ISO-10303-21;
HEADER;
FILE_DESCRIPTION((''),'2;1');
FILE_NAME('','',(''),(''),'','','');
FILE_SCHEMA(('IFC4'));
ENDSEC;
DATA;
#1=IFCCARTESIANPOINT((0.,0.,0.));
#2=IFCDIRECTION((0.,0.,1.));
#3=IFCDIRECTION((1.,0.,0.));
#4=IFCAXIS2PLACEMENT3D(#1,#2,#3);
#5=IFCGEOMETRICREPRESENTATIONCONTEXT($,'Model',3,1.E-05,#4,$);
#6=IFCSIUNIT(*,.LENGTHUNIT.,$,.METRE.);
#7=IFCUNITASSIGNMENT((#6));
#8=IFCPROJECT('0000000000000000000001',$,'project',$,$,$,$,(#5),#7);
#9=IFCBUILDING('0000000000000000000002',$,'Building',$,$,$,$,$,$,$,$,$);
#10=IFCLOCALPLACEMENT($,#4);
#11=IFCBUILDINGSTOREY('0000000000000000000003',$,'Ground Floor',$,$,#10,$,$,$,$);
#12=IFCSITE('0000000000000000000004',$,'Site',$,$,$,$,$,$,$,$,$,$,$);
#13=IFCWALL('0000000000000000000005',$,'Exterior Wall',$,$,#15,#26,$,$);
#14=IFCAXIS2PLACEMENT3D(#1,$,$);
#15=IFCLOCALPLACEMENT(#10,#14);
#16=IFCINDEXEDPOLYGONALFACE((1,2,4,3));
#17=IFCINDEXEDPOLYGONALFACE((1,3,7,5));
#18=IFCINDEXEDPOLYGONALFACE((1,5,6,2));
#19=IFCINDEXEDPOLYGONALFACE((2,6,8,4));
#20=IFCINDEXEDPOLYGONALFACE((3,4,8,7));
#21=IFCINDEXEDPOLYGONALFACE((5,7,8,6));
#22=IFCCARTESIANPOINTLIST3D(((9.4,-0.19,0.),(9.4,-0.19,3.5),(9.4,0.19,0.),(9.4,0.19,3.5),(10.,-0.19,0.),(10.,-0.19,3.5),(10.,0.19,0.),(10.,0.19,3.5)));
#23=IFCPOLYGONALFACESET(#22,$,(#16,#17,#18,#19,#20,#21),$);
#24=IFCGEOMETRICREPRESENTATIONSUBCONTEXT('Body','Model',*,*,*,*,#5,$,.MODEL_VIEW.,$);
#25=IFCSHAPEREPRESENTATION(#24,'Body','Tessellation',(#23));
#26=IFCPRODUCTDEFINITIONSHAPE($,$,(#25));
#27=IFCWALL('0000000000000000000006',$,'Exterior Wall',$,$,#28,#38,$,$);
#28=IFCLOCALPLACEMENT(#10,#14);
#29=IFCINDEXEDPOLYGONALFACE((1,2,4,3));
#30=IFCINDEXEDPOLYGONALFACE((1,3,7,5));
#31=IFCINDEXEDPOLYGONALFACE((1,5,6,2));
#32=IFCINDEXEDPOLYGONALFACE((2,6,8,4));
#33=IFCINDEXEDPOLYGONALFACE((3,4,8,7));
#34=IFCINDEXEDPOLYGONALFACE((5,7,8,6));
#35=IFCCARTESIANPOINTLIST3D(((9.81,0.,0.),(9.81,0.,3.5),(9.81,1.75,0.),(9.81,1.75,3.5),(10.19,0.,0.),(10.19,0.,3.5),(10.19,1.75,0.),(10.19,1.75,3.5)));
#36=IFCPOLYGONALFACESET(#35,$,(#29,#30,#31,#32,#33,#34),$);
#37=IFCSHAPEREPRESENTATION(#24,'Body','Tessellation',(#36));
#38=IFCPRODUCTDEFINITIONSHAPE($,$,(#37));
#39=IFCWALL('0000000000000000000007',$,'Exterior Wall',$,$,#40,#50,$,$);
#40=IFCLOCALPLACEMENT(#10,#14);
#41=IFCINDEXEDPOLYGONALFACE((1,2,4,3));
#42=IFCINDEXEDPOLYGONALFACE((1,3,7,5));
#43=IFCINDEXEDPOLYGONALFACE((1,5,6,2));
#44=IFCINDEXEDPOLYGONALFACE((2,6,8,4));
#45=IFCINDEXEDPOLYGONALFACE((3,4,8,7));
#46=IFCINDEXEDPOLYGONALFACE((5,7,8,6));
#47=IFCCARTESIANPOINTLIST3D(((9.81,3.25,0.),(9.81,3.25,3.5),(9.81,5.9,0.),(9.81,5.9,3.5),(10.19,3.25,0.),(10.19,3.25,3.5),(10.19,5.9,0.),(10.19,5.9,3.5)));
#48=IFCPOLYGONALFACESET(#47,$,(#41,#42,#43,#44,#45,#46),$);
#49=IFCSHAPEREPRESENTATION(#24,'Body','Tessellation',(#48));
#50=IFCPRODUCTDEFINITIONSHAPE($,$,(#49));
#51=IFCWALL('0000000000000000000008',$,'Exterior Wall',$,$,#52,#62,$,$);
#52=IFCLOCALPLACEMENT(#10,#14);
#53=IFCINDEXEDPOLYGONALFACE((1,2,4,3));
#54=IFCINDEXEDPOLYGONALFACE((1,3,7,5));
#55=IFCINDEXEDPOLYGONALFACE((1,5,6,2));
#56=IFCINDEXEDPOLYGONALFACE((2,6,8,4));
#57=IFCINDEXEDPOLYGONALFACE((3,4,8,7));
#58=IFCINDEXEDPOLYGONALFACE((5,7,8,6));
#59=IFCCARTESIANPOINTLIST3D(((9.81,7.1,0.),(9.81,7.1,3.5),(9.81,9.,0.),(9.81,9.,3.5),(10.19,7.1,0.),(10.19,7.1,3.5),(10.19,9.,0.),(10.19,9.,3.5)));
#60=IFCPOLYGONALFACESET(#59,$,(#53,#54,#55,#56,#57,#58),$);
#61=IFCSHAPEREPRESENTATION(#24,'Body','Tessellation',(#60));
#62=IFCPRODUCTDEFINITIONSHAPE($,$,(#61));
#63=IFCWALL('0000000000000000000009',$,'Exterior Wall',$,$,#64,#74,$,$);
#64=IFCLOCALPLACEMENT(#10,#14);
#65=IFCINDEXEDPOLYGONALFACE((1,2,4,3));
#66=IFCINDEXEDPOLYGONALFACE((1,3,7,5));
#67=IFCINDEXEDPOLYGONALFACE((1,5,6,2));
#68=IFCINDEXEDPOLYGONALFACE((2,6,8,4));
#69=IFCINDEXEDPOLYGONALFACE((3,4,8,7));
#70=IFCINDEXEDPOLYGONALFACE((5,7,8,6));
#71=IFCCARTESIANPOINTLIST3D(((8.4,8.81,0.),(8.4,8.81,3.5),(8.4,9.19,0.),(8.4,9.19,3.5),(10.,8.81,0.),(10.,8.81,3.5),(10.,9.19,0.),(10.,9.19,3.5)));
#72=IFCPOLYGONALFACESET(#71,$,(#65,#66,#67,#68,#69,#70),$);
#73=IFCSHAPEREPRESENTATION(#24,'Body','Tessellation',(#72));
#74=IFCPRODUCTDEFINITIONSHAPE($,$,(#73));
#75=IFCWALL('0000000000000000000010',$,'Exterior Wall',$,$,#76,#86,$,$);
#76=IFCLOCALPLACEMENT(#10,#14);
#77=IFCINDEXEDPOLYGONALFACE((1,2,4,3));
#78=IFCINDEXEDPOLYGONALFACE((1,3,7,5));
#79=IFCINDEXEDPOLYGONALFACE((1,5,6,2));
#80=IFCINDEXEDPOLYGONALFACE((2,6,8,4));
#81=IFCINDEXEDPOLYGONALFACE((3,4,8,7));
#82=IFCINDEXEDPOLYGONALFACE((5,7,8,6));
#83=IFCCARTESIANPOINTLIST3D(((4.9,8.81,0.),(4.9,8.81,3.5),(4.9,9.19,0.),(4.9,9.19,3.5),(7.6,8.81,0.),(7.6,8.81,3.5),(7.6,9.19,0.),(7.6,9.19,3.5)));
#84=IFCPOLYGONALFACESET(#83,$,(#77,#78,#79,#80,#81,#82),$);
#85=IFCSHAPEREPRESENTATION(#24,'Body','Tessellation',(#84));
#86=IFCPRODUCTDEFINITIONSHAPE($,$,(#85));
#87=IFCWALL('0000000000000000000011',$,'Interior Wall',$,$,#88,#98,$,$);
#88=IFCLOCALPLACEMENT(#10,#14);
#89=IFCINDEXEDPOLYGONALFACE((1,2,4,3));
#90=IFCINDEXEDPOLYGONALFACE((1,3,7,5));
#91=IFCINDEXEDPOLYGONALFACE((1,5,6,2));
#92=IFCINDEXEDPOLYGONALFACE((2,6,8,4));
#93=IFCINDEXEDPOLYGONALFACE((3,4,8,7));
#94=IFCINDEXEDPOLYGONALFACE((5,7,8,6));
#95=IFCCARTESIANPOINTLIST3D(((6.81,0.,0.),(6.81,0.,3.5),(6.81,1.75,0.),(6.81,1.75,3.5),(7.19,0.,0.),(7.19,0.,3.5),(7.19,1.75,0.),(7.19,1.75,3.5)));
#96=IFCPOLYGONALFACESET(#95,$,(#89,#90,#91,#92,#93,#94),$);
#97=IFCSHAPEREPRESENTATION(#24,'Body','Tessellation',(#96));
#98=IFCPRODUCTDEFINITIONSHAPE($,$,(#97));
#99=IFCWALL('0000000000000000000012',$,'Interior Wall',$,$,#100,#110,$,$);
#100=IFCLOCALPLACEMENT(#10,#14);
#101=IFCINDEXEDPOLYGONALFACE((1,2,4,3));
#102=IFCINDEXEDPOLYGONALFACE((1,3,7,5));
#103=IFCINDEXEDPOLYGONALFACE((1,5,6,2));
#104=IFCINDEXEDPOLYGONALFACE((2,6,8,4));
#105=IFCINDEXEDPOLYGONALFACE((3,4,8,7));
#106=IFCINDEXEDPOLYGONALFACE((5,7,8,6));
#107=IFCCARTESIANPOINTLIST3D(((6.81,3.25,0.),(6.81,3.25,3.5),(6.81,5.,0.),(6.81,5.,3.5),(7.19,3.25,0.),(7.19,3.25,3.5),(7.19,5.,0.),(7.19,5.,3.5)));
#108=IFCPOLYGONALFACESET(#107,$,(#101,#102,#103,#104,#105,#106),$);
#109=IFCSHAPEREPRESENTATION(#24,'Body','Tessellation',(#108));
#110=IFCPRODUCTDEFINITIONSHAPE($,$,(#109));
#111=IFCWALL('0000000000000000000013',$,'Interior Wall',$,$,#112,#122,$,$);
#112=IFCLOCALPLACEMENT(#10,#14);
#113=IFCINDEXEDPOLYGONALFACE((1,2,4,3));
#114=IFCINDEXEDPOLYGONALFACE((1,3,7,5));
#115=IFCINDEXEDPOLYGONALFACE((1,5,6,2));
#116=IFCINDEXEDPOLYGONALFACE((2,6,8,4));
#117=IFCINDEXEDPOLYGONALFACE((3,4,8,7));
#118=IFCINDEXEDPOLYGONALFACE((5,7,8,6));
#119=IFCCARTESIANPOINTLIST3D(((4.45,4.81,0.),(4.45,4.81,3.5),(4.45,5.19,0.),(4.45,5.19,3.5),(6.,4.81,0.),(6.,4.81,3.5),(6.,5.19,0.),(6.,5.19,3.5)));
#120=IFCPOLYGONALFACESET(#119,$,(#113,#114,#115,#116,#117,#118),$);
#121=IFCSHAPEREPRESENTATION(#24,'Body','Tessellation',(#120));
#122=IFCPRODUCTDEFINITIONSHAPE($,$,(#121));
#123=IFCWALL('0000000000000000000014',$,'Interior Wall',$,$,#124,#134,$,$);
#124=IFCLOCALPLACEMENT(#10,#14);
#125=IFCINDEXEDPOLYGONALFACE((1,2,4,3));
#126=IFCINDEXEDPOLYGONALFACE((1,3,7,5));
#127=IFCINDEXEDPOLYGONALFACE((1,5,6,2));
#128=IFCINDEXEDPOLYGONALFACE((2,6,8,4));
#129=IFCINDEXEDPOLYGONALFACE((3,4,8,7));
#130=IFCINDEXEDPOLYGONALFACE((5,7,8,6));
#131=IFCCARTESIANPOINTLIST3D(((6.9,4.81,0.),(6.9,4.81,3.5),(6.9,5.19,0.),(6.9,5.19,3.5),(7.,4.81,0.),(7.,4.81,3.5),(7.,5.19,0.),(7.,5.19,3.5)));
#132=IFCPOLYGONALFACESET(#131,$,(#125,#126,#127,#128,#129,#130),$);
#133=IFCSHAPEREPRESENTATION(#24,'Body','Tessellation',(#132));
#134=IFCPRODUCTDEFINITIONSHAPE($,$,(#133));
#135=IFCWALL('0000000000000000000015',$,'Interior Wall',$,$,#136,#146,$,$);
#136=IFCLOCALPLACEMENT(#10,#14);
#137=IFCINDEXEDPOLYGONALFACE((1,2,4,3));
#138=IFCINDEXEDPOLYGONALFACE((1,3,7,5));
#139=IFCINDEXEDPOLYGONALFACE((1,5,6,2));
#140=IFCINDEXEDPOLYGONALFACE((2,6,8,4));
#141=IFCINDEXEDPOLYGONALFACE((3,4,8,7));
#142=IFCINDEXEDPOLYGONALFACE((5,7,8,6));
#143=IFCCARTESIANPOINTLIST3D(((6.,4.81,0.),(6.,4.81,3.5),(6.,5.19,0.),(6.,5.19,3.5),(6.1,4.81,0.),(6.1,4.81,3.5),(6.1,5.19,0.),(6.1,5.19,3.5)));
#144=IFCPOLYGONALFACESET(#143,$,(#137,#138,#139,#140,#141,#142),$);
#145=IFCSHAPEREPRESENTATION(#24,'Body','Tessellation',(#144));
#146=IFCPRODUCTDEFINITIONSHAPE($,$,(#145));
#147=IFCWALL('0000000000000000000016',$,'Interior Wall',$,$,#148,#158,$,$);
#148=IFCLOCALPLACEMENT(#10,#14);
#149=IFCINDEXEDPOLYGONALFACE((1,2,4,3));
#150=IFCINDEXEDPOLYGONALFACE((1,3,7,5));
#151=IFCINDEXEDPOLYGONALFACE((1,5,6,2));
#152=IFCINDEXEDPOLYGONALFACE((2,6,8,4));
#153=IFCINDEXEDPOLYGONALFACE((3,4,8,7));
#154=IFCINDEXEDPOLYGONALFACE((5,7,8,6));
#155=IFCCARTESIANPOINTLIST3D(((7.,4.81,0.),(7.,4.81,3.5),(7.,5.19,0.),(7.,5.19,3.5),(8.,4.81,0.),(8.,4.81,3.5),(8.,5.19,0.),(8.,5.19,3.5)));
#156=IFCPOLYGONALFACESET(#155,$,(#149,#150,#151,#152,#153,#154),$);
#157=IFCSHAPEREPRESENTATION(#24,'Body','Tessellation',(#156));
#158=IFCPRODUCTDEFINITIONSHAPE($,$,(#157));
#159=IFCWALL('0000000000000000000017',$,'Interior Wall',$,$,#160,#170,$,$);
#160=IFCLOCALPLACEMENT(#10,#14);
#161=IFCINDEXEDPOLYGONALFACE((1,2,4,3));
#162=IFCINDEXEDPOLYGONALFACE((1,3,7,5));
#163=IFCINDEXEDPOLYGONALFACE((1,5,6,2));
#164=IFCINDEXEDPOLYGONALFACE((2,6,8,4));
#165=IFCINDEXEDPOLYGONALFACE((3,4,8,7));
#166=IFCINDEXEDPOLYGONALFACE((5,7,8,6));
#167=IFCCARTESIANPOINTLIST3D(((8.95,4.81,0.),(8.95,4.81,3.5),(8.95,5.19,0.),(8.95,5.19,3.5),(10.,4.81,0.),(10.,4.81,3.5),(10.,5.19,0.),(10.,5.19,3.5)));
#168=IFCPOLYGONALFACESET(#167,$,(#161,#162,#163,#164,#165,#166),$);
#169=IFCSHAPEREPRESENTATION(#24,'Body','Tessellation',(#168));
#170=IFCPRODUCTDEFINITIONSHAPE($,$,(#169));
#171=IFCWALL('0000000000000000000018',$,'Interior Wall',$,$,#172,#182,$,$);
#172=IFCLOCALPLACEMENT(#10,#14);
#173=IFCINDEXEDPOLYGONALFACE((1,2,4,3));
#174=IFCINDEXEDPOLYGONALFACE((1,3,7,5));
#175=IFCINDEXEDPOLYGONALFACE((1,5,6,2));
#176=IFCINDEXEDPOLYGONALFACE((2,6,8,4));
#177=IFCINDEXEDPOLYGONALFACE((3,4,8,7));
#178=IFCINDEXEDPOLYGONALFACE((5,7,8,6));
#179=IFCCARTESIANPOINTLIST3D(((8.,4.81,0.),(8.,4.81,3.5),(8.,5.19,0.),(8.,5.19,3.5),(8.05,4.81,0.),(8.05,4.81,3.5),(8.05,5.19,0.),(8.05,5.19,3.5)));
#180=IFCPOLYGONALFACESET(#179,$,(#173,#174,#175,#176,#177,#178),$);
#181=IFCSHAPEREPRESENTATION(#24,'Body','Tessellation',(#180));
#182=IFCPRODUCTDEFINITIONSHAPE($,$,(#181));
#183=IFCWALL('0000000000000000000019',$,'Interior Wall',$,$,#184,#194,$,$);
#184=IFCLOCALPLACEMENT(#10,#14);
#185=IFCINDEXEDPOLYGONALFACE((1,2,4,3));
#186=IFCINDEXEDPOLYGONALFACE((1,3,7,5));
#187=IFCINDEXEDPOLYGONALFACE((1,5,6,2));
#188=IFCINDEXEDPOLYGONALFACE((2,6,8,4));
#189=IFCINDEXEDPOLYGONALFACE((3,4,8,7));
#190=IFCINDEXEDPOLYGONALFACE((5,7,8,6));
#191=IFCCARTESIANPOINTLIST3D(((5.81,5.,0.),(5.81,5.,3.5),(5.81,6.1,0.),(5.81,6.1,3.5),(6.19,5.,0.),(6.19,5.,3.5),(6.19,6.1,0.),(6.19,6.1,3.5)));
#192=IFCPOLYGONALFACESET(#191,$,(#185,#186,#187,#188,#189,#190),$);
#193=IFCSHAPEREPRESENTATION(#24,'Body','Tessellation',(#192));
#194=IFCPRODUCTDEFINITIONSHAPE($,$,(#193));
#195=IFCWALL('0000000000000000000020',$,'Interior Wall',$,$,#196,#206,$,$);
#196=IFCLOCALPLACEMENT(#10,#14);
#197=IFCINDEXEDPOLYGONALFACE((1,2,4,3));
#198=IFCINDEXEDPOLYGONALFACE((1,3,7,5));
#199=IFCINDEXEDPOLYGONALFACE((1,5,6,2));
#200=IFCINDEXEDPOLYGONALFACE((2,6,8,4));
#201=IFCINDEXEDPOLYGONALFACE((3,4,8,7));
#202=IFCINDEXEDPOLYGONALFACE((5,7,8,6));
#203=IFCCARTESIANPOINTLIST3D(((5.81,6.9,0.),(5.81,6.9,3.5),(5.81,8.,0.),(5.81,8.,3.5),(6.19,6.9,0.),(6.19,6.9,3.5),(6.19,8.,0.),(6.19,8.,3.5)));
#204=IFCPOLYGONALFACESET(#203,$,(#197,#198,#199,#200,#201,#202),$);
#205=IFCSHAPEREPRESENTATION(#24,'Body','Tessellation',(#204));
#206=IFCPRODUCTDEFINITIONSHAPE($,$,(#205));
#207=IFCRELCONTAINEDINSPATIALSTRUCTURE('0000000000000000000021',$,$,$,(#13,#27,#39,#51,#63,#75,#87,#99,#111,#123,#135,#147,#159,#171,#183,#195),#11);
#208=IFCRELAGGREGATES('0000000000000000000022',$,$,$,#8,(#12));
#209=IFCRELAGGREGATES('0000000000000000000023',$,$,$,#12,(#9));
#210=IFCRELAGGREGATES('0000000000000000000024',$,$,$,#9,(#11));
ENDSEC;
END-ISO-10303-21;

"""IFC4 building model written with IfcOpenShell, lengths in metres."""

from ifc_helpers import new_model, si_unit, frame, origin_with_axes, place, context, subcontext, project, spatial, indexed_curve, outline, extrude, element, save


model = new_model("IFC4")

# Units and contexts
model_context = context("Model", 3, precision=1e-05, world=origin_with_axes())
body_context = subcontext(model_context, "Body", "Model", "MODEL_VIEW")
ifc_project = project(units=[si_unit("LENGTHUNIT", "METRE")], contexts=[model_context])

# Site, building, storey
site = spatial("IfcSite", under=ifc_project, Name="Site")
building = spatial("IfcBuilding", under=site, Name="Building")
storey_placement = place(None, origin_with_axes())
storey = spatial("IfcBuildingStorey", under=building, at=storey_placement, Name="Ground Floor")

# Walls
wall_1_placement = place(storey_placement, frame((9.4, 0.0, 0.0), z_axis=(0.0, 0.0, 1.0), x_axis=(1.0, 0.0, 0.0)))
element("IfcWall", 1, at=wall_1_placement, inside=storey, Name="Exterior Wall", context=body_context, shape_type="SweptSolid", body=[
    extrude(outline(indexed_curve([(0.0, 0.0), (0.0, 0.38), (0.6, 0.38), (0.6, 0.0), (0.0, 0.0)], self_intersect=False)), frame((0.0, -0.19, 0.0), z_axis=(0.0, 0.0, 1.0), x_axis=(1.0, 0.0, 0.0)), (0.0, 0.0, 1.0), 3.5),
])
wall_2_placement = place(storey_placement, frame((10.0, 0.0, 0.0), z_axis=(0.0, 0.0, 1.0), x_axis=(0.0, 1.0, 0.0)))
element("IfcWall", 2, at=wall_2_placement, inside=storey, Name="Exterior Wall", context=body_context, shape_type="SweptSolid", body=[
    extrude(outline(indexed_curve([(0.0, 0.0), (0.0, 0.38), (1.75, 0.38), (1.75, 0.0), (0.0, 0.0)], self_intersect=False)), frame((0.0, -0.19, 0.0), z_axis=(0.0, 0.0, 1.0), x_axis=(1.0, 0.0, 0.0)), (0.0, 0.0, 1.0), 3.5),
])
wall_3_placement = place(storey_placement, frame((10.0, 3.25, 0.0), z_axis=(0.0, 0.0, 1.0), x_axis=(0.0, 1.0, 0.0)))
element("IfcWall", 3, at=wall_3_placement, inside=storey, Name="Exterior Wall", context=body_context, shape_type="SweptSolid", body=[
    extrude(outline(indexed_curve([(0.0, 0.0), (0.0, 0.38), (2.65, 0.38), (2.65, 0.0), (0.0, 0.0)], self_intersect=False)), frame((0.0, -0.19, 0.0), z_axis=(0.0, 0.0, 1.0), x_axis=(1.0, 0.0, 0.0)), (0.0, 0.0, 1.0), 3.5),
])
wall_4_placement = place(storey_placement, frame((10.0, 7.1, 0.0), z_axis=(0.0, 0.0, 1.0), x_axis=(0.0, 1.0, 0.0)))
element("IfcWall", 4, at=wall_4_placement, inside=storey, Name="Exterior Wall", context=body_context, shape_type="SweptSolid", body=[
    extrude(outline(indexed_curve([(0.0, 0.0), (0.0, 0.38), (1.9, 0.38), (1.9, 0.0), (0.0, 0.0)], self_intersect=False)), frame((0.0, -0.19, 0.0), z_axis=(0.0, 0.0, 1.0), x_axis=(1.0, 0.0, 0.0)), (0.0, 0.0, 1.0), 3.5),
])
wall_5_placement = place(storey_placement, frame((10.0, 9.0, 0.0), z_axis=(0.0, 0.0, 1.0), x_axis=(-1.0, 0.0, 0.0)))
element("IfcWall", 5, at=wall_5_placement, inside=storey, Name="Exterior Wall", context=body_context, shape_type="SweptSolid", body=[
    extrude(outline(indexed_curve([(0.0, 0.0), (0.0, 0.38), (1.6, 0.38), (1.6, 0.0), (0.0, 0.0)], self_intersect=False)), frame((0.0, -0.19, 0.0), z_axis=(0.0, 0.0, 1.0), x_axis=(1.0, 0.0, 0.0)), (0.0, 0.0, 1.0), 3.5),
])
wall_6_placement = place(storey_placement, frame((7.6, 9.0, 0.0), z_axis=(0.0, 0.0, 1.0), x_axis=(-1.0, 0.0, 0.0)))
element("IfcWall", 6, at=wall_6_placement, inside=storey, Name="Exterior Wall", context=body_context, shape_type="SweptSolid", body=[
    extrude(outline(indexed_curve([(0.0, 0.0), (0.0, 0.38), (2.7, 0.38), (2.7, 0.0), (0.0, 0.0)], self_intersect=False)), frame((0.0, -0.19, 0.0), z_axis=(0.0, 0.0, 1.0), x_axis=(1.0, 0.0, 0.0)), (0.0, 0.0, 1.0), 3.5),
])
for number, where, z_axis, x_axis, name in (
    (7, (7.0, 0.0, 0.0), (0.0, 0.0, 1.0), (0.0, 1.0, 0.0), "Interior Wall"),
    (8, (7.0, 3.25, 0.0), (0.0, 0.0, 1.0), (0.0, 1.0, 0.0), "Interior Wall"),
):
    element("IfcWall", number, at=place(storey_placement, frame(where, z_axis=z_axis, x_axis=x_axis)), inside=storey, Name=name, context=body_context, shape_type="SweptSolid", body=[
        extrude(outline(indexed_curve([(0.0, 0.0), (0.0, 0.38), (1.75, 0.38), (1.75, 0.0), (0.0, 0.0)], self_intersect=False)), frame((0.0, -0.19, 0.0), z_axis=(0.0, 0.0, 1.0), x_axis=(1.0, 0.0, 0.0)), (0.0, 0.0, 1.0), 3.5),
    ])
wall_7_placement = place(storey_placement, frame((6.0, 5.0, 0.0), z_axis=(0.0, 0.0, 1.0), x_axis=(-1.0, 0.0, 0.0)))
element("IfcWall", 9, at=wall_7_placement, inside=storey, Name="Interior Wall", context=body_context, shape_type="SweptSolid", body=[
    extrude(outline(indexed_curve([(0.0, 0.0), (0.0, 0.38), (1.55, 0.38), (1.55, 0.0), (0.0, 0.0)], self_intersect=False)), frame((0.0, -0.19, 0.0), z_axis=(0.0, 0.0, 1.0), x_axis=(1.0, 0.0, 0.0)), (0.0, 0.0, 1.0), 3.5),
])
for number, where, z_axis, x_axis, name in (
    (10, (7.0, 5.0, 0.0), (0.0, 0.0, 1.0), (-1.0, 0.0, 0.0), "Interior Wall"),
    (11, (6.1, 5.0, 0.0), (0.0, 0.0, 1.0), (-1.0, 0.0, 0.0), "Interior Wall"),
):
    element("IfcWall", number, at=place(storey_placement, frame(where, z_axis=z_axis, x_axis=x_axis)), inside=storey, Name=name, context=body_context, shape_type="SweptSolid", body=[
        extrude(outline(indexed_curve([(0.0, 0.0), (0.0, 0.38), (0.1, 0.38), (0.1, 0.0), (0.0, 0.0)], self_intersect=False)), frame((0.0, -0.19, 0.0), z_axis=(0.0, 0.0, 1.0), x_axis=(1.0, 0.0, 0.0)), (0.0, 0.0, 1.0), 3.5),
    ])
wall_8_placement = place(storey_placement, frame((8.0, 5.0, 0.0), z_axis=(0.0, 0.0, 1.0), x_axis=(-1.0, 0.0, 0.0)))
element("IfcWall", 12, at=wall_8_placement, inside=storey, Name="Interior Wall", context=body_context, shape_type="SweptSolid", body=[
    extrude(outline(indexed_curve([(0.0, 0.0), (0.0, 0.38), (1.0, 0.38), (1.0, 0.0), (0.0, 0.0)], self_intersect=False)), frame((0.0, -0.19, 0.0), z_axis=(0.0, 0.0, 1.0), x_axis=(1.0, 0.0, 0.0)), (0.0, 0.0, 1.0), 3.5),
])
wall_9_placement = place(storey_placement, frame((10.0, 5.0, 0.0), z_axis=(0.0, 0.0, 1.0), x_axis=(-1.0, 0.0, 0.0)))
element("IfcWall", 13, at=wall_9_placement, inside=storey, Name="Interior Wall", context=body_context, shape_type="SweptSolid", body=[
    extrude(outline(indexed_curve([(0.0, 0.0), (0.0, 0.38), (1.05, 0.38), (1.05, 0.0), (0.0, 0.0)], self_intersect=False)), frame((0.0, -0.19, 0.0), z_axis=(0.0, 0.0, 1.0), x_axis=(1.0, 0.0, 0.0)), (0.0, 0.0, 1.0), 3.5),
])
wall_10_placement = place(storey_placement, frame((8.05, 5.0, 0.0), z_axis=(0.0, 0.0, 1.0), x_axis=(-1.0, 0.0, 0.0)))
element("IfcWall", 14, at=wall_10_placement, inside=storey, Name="Interior Wall", context=body_context, shape_type="SweptSolid", body=[
    extrude(outline(indexed_curve([(0.0, 0.0), (0.0, 0.38), (0.05, 0.38), (0.05, 0.0), (0.0, 0.0)], self_intersect=False)), frame((0.0, -0.19, 0.0), z_axis=(0.0, 0.0, 1.0), x_axis=(1.0, 0.0, 0.0)), (0.0, 0.0, 1.0), 3.5),
])
for number, where, z_axis, x_axis, name in (
    (15, (6.0, 5.0, 0.0), (0.0, 0.0, 1.0), (0.0, 1.0, 0.0), "Interior Wall"),
    (16, (6.0, 6.9, 0.0), (0.0, 0.0, 1.0), (0.0, 1.0, 0.0), "Interior Wall"),
):
    element("IfcWall", number, at=place(storey_placement, frame(where, z_axis=z_axis, x_axis=x_axis)), inside=storey, Name=name, context=body_context, shape_type="SweptSolid", body=[
        extrude(outline(indexed_curve([(0.0, 0.0), (0.0, 0.38), (1.1, 0.38), (1.1, 0.0), (0.0, 0.0)], self_intersect=False)), frame((0.0, -0.19, 0.0), z_axis=(0.0, 0.0, 1.0), x_axis=(1.0, 0.0, 0.0)), (0.0, 0.0, 1.0), 3.5),
    ])

save(model, "model.ifc")
